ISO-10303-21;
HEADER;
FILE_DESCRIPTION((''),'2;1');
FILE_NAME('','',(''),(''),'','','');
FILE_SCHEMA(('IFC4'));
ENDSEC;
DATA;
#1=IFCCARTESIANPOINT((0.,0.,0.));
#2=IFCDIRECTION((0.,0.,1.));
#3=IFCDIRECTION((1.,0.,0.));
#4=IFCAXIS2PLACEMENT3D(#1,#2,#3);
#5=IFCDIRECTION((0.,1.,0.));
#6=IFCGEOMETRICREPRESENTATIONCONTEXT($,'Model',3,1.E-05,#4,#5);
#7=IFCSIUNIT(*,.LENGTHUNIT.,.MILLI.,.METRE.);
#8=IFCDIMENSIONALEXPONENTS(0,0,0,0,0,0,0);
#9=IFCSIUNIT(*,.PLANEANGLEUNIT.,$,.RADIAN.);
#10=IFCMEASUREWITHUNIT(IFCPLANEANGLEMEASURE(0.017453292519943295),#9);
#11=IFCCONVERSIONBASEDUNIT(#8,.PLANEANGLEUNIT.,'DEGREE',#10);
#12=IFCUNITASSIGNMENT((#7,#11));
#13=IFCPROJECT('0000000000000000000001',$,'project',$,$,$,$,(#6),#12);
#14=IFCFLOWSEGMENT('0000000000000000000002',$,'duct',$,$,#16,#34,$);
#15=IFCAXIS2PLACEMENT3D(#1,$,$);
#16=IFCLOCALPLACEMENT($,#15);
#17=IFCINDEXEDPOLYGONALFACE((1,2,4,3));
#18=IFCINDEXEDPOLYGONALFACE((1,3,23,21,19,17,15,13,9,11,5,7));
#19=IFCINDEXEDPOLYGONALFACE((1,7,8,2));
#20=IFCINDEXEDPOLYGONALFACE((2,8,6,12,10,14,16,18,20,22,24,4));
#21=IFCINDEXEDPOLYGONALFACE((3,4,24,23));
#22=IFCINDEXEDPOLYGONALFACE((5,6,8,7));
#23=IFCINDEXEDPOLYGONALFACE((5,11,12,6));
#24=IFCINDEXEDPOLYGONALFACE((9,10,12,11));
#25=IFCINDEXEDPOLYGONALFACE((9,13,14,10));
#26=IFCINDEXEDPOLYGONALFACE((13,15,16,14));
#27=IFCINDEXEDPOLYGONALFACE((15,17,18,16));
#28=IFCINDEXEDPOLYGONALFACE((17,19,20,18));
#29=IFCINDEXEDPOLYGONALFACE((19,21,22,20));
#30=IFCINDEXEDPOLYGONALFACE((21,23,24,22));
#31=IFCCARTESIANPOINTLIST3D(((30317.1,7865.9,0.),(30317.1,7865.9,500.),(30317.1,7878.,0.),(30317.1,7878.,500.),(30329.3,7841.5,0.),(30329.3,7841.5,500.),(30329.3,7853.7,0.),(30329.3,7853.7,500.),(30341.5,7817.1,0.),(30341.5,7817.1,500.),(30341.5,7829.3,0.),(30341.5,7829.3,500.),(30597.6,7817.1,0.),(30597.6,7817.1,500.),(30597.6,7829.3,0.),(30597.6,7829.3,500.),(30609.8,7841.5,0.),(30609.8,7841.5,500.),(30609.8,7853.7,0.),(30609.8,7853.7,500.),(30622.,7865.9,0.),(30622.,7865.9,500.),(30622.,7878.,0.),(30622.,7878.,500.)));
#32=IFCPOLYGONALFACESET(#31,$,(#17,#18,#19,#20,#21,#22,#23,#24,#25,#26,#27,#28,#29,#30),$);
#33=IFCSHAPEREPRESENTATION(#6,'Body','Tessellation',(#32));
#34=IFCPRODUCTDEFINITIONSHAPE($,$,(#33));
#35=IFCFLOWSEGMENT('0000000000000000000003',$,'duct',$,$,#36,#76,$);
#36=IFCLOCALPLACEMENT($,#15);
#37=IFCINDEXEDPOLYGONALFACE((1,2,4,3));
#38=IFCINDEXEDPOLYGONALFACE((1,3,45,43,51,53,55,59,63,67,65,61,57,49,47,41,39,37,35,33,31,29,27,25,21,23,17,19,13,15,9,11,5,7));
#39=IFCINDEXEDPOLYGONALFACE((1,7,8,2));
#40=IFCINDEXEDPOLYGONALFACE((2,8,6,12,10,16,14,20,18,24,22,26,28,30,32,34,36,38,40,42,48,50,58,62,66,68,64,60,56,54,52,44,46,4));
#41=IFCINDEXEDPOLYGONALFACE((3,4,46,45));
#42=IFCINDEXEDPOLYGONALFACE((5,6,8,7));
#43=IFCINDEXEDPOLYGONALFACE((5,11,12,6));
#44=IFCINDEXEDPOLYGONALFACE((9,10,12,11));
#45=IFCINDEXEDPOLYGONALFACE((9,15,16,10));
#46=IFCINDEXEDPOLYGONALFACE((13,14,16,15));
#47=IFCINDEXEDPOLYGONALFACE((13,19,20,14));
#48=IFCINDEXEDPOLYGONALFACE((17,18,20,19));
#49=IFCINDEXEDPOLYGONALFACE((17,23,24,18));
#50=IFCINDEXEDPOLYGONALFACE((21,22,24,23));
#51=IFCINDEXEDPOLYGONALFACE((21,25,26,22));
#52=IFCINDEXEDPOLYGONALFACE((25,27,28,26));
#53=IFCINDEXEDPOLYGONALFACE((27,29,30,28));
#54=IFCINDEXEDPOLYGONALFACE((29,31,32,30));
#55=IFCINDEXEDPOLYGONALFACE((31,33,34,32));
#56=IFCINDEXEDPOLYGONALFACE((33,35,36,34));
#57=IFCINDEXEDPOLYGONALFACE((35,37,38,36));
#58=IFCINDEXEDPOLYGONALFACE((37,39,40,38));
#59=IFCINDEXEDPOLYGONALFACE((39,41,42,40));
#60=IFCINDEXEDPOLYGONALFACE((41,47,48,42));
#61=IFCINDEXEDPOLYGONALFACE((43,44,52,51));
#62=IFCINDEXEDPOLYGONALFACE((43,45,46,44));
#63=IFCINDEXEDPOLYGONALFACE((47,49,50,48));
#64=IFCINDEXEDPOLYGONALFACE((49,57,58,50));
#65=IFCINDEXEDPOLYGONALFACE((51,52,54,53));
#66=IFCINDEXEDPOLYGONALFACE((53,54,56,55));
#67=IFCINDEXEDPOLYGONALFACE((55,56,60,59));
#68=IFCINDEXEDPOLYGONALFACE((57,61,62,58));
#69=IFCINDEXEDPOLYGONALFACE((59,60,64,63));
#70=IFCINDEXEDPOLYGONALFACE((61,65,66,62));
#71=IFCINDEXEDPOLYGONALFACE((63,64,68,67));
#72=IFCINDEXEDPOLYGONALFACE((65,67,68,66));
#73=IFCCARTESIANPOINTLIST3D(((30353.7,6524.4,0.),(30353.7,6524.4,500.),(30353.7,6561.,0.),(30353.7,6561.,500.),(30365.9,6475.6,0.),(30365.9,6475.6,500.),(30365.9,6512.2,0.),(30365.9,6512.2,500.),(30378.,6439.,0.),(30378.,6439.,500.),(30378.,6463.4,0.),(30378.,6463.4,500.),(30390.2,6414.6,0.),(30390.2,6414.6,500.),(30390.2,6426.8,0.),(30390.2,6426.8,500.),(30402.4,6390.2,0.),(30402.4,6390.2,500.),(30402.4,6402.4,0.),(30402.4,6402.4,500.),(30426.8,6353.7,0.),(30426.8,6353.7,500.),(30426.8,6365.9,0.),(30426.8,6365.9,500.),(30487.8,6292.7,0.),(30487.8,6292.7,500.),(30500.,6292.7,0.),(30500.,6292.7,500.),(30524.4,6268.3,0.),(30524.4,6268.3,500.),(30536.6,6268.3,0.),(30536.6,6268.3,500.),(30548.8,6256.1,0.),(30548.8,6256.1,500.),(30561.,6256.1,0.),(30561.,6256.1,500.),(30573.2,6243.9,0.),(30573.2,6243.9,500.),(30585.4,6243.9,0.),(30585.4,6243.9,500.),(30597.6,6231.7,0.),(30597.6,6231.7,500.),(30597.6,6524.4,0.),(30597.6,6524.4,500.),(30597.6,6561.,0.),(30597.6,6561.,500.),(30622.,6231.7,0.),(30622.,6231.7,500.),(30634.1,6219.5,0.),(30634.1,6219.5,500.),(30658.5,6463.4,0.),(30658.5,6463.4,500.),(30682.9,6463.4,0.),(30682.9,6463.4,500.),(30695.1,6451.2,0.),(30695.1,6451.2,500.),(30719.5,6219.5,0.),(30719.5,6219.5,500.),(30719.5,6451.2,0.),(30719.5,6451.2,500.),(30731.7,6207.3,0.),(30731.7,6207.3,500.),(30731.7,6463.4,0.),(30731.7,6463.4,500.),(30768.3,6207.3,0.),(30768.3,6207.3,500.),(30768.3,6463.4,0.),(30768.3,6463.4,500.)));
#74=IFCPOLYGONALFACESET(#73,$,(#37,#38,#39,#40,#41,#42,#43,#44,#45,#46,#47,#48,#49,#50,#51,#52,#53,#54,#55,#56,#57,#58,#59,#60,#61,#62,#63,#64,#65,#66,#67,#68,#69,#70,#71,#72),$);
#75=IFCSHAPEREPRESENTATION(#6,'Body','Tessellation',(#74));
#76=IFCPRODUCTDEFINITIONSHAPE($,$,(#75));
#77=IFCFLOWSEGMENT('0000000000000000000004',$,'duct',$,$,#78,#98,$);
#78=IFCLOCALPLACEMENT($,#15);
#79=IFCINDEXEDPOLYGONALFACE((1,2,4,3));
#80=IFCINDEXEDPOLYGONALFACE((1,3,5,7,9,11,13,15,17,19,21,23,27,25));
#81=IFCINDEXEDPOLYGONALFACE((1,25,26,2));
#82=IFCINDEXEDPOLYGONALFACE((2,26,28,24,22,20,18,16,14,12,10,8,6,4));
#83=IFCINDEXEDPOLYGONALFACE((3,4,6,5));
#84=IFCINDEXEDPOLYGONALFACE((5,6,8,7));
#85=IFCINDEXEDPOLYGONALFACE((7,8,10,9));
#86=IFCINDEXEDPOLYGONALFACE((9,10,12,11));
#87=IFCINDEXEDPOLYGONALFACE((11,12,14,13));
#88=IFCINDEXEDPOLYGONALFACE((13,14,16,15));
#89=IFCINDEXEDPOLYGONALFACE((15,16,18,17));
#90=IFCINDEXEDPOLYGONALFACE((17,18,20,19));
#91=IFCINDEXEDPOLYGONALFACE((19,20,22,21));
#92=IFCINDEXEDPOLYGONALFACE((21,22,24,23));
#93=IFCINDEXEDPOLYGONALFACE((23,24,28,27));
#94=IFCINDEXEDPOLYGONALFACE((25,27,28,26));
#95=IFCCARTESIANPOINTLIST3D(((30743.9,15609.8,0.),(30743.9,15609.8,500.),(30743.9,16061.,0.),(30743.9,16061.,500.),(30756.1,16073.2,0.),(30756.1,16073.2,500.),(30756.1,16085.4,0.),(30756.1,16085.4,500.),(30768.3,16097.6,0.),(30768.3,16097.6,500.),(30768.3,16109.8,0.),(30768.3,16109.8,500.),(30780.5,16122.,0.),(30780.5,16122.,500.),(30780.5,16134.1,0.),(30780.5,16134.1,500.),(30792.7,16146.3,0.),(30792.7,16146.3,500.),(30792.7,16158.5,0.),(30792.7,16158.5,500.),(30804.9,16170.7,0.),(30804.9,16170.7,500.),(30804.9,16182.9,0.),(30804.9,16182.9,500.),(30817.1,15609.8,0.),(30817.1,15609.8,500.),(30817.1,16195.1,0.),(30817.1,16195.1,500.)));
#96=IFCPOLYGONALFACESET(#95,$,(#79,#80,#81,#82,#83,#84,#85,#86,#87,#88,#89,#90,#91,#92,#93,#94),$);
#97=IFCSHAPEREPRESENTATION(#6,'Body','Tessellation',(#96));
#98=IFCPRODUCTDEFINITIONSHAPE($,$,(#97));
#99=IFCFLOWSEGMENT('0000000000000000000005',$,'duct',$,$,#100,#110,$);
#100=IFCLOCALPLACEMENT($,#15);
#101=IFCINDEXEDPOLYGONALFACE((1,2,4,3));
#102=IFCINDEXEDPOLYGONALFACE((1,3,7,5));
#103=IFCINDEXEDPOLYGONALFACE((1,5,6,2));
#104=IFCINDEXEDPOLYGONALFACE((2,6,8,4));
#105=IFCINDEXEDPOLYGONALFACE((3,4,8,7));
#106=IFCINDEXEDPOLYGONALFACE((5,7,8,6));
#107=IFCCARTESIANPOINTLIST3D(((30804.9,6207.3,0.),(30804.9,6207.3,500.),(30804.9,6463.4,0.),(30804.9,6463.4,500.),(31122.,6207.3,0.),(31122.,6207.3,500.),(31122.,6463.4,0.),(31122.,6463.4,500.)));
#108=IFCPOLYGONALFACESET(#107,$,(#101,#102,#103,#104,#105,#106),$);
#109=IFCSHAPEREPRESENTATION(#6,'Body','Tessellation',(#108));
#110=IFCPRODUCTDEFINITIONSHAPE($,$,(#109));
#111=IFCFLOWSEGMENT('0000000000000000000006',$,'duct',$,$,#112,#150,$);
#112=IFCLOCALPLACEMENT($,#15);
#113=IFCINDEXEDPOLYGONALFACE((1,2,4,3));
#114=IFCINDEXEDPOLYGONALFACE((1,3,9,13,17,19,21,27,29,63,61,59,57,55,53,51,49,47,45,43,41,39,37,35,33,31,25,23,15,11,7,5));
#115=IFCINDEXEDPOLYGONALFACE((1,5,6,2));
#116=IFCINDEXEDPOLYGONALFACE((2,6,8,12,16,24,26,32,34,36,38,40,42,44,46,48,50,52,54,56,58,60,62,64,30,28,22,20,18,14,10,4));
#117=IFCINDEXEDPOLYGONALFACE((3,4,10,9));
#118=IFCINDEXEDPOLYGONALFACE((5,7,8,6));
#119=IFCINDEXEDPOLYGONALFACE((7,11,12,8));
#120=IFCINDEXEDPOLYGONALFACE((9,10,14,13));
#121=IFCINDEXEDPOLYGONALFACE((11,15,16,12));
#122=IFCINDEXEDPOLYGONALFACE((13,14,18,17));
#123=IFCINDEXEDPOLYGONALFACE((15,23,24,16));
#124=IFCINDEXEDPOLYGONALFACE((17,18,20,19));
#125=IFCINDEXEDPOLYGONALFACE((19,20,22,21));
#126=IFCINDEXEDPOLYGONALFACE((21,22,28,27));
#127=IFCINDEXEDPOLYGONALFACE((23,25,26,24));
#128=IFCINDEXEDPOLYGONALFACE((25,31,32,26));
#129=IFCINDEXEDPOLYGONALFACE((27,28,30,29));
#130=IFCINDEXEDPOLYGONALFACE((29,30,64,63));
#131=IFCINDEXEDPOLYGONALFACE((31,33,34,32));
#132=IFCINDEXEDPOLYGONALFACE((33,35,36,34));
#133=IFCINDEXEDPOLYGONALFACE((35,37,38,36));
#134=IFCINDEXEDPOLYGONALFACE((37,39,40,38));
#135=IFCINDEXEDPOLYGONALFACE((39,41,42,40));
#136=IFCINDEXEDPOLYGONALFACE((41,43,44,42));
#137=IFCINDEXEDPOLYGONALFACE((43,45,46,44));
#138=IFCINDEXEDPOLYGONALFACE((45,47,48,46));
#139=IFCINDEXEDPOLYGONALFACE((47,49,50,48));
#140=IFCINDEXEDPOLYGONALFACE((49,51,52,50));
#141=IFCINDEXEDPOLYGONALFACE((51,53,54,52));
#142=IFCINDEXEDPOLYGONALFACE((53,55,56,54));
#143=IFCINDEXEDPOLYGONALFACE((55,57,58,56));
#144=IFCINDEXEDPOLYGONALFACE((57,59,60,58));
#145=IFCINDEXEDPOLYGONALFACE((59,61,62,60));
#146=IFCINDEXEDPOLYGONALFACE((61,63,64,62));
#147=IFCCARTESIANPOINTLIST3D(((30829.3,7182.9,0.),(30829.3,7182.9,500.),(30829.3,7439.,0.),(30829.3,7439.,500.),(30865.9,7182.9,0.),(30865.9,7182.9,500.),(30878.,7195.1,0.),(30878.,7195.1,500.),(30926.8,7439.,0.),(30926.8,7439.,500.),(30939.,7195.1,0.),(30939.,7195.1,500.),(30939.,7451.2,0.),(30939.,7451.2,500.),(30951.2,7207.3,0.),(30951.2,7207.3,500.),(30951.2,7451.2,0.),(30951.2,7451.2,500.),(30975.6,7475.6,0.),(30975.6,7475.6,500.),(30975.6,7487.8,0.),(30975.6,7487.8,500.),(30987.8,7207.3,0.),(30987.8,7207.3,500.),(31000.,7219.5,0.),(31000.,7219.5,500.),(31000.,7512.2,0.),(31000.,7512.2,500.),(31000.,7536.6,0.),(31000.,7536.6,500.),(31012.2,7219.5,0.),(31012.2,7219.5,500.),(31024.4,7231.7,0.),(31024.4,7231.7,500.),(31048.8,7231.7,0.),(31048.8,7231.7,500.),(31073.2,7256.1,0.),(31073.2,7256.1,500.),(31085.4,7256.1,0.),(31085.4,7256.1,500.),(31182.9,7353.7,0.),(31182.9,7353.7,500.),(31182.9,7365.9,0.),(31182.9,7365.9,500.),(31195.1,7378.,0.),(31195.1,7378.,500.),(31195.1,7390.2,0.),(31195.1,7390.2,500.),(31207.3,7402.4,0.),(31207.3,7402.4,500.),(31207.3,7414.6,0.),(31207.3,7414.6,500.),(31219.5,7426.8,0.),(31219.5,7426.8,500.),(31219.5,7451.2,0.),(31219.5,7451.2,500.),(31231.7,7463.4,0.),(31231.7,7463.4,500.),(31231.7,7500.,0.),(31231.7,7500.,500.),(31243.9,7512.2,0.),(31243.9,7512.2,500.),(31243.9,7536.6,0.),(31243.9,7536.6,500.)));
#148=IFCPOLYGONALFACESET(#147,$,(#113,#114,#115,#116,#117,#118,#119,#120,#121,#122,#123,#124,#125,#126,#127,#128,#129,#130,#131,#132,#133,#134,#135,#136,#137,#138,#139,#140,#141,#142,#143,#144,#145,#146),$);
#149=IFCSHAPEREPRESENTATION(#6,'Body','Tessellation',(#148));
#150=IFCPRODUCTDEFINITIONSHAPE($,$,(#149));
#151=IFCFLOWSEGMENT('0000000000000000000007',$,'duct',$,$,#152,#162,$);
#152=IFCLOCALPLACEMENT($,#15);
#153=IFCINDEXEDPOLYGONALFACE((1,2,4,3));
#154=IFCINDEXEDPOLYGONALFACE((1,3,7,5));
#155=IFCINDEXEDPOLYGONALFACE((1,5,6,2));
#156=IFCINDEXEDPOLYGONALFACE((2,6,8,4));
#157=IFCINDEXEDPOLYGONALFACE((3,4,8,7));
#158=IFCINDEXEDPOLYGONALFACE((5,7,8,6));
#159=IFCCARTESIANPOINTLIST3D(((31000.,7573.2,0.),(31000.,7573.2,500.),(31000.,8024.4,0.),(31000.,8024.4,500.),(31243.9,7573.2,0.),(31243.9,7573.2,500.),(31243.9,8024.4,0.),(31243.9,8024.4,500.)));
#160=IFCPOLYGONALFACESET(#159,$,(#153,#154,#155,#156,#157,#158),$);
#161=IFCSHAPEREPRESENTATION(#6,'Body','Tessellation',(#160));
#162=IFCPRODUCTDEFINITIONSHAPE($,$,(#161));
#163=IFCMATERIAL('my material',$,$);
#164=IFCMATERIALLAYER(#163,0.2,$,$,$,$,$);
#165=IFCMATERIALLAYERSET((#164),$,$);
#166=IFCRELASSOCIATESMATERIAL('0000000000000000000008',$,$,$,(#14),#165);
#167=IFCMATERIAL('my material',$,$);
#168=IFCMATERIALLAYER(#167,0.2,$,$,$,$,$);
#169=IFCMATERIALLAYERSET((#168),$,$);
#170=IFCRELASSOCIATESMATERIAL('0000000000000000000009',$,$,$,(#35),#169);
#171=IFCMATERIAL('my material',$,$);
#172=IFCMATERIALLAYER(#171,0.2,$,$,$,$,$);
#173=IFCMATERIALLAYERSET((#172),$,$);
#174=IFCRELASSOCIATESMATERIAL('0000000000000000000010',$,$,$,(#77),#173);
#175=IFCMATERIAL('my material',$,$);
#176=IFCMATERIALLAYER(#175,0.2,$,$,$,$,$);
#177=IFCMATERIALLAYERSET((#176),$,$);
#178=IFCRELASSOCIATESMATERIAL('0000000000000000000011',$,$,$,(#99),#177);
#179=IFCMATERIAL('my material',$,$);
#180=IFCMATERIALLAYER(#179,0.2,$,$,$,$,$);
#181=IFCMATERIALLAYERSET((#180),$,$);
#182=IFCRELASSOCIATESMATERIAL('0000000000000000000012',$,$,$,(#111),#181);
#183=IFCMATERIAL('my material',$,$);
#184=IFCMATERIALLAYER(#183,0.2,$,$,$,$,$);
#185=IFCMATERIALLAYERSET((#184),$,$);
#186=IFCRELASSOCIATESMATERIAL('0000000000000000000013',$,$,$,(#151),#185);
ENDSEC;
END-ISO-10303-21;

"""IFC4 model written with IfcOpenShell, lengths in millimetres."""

from ifc_helpers import new_model, entity, si_unit, converted_unit, direction, origin_with_axes, place, context, project, polyline, outline, extrude, material, layer, layer_set, layer_usage, element, save


model = new_model("IFC4")

# Units and contexts
model_context = context("Model", 3, precision=1e-05, world=origin_with_axes(), true_north=direction((0.0, 1.0, 0.0)))
ifc_project = project(units=[si_unit("LENGTHUNIT", "METRE", prefix="MILLI"), converted_unit("PLANEANGLEUNIT", "DEGREE", entity("IfcPlaneAngleMeasure", 0.017453292519943295), si_unit("PLANEANGLEUNIT", "RADIAN"), dimensions=[0, 0, 0, 0, 0, 0, 0])], contexts=[model_context])

# Flow segments
ifc_material_1 = material(Name="my material")
ifc_layer_1 = layer(ifc_material_1, 0.2)
ifc_layer_set_1 = layer_set([ifc_layer_1])
ifc_layer_usage_1 = layer_usage(ifc_layer_set_1, "AXIS2", "POSITIVE", -0.1)
flow_segment_1_placement = place(None, origin_with_axes())
element("IfcFlowSegment", 1, at=flow_segment_1_placement, material=ifc_layer_usage_1, Name="duct", context=model_context, shape_type="SweptSolid", body=[
    extrude(outline(polyline([(30317.1, 7865.9), (30329.3, 7853.7), (30329.3, 7841.5), (30341.5, 7829.3), (30341.5, 7817.1), (30597.6, 7817.1), (30597.6, 7829.3), (30609.8, 7841.5), (30609.8, 7853.7), (30622.0, 7865.9), (30622.0, 7878.0), (30317.1, 7878.0), (30317.1, 7865.9)])), origin_with_axes(), (0.0, 0.0, 1.0), 500.0),
])
ifc_material_2 = material(Name="my material")
ifc_layer_2 = layer(ifc_material_2, 0.2)
ifc_layer_set_2 = layer_set([ifc_layer_2])
ifc_layer_usage_2 = layer_usage(ifc_layer_set_2, "AXIS2", "POSITIVE", -0.1)
flow_segment_2_placement = place(None, origin_with_axes())
element("IfcFlowSegment", 2, at=flow_segment_2_placement, material=ifc_layer_usage_2, Name="duct", context=model_context, shape_type="SweptSolid", body=[
    extrude(outline(polyline([(30353.7, 6524.4), (30365.9, 6512.2), (30365.9, 6475.6), (30378.0, 6463.4), (30378.0, 6439.0), (30390.2, 6426.8), (30390.2, 6414.6), (30402.4, 6402.4), (30402.4, 6390.2), (30426.8, 6365.9), (30426.8, 6353.7), (30487.8, 6292.7), (30500.0, 6292.7), (30524.4, 6268.3), (30536.6, 6268.3), (30548.8, 6256.1), (30561.0, 6256.1), (30573.2, 6243.9), (30585.4, 6243.9), (30597.6, 6231.7), (30622.0, 6231.7), (30634.1, 6219.5), (30719.5, 6219.5), (30731.7, 6207.3), (30768.3, 6207.3), (30768.3, 6463.4), (30731.7, 6463.4), (30719.5, 6451.2), (30695.1, 6451.2), (30682.9, 6463.4), (30658.5, 6463.4), (30597.6, 6524.4), (30597.6, 6561.0), (30353.7, 6561.0), (30353.7, 6524.4)])), origin_with_axes(), (0.0, 0.0, 1.0), 500.0),
])
ifc_material_3 = material(Name="my material")
ifc_layer_3 = layer(ifc_material_3, 0.2)
ifc_layer_set_3 = layer_set([ifc_layer_3])
ifc_layer_usage_3 = layer_usage(ifc_layer_set_3, "AXIS2", "POSITIVE", -0.1)
flow_segment_3_placement = place(None, origin_with_axes())
element("IfcFlowSegment", 3, at=flow_segment_3_placement, material=ifc_layer_usage_3, Name="duct", context=model_context, shape_type="SweptSolid", body=[
    extrude(outline(polyline([(30743.9, 15609.8), (30817.1, 15609.8), (30817.1, 16207.3), (30817.1, 16195.1), (30804.9, 16182.9), (30804.9, 16170.7), (30792.7, 16158.5), (30792.7, 16146.3), (30780.5, 16134.1), (30780.5, 16122.0), (30768.3, 16109.8), (30768.3, 16097.6), (30756.1, 16085.4), (30756.1, 16073.2), (30743.9, 16061.0), (30743.9, 15609.8)])), origin_with_axes(), (0.0, 0.0, 1.0), 500.0),
])
ifc_material_4 = material(Name="my material")
ifc_layer_4 = layer(ifc_material_4, 0.2)
ifc_layer_set_4 = layer_set([ifc_layer_4])
ifc_layer_usage_4 = layer_usage(ifc_layer_set_4, "AXIS2", "POSITIVE", -0.1)
flow_segment_4_placement = place(None, origin_with_axes())
element("IfcFlowSegment", 4, at=flow_segment_4_placement, material=ifc_layer_usage_4, Name="duct", context=model_context, shape_type="SweptSolid", body=[
    extrude(outline(polyline([(30804.9, 6207.3), (31122.0, 6207.3), (31122.0, 6463.4), (30804.9, 6463.4), (30804.9, 6207.3)])), origin_with_axes(), (0.0, 0.0, 1.0), 500.0),
])
ifc_material_5 = material(Name="my material")
ifc_layer_5 = layer(ifc_material_5, 0.2)
ifc_layer_set_5 = layer_set([ifc_layer_5])
ifc_layer_usage_5 = layer_usage(ifc_layer_set_5, "AXIS2", "POSITIVE", -0.1)
flow_segment_5_placement = place(None, origin_with_axes())
element("IfcFlowSegment", 5, at=flow_segment_5_placement, material=ifc_layer_usage_5, Name="duct", context=model_context, shape_type="SweptSolid", body=[
    extrude(outline(polyline([(30829.3, 7182.9), (30865.9, 7182.9), (30878.0, 7195.1), (30939.0, 7195.1), (30951.2, 7207.3), (30987.8, 7207.3), (31000.0, 7219.5), (31012.2, 7219.5), (31024.4, 7231.7), (31048.8, 7231.7), (31073.2, 7256.1), (31085.4, 7256.1), (31182.9, 7353.7), (31182.9, 7365.9), (31195.1, 7378.0), (31195.1, 7390.2), (31207.3, 7402.4), (31207.3, 7414.6), (31219.5, 7426.8), (31219.5, 7451.2), (31231.7, 7463.4), (31231.7, 7500.0), (31243.9, 7512.2), (31243.9, 7536.6), (31000.0, 7536.6), (31000.0, 7512.2), (30975.6, 7487.8), (30975.6, 7475.6), (30951.2, 7451.2), (30939.0, 7451.2), (30926.8, 7439.0), (30829.3, 7439.0), (30829.3, 7182.9)])), origin_with_axes(), (0.0, 0.0, 1.0), 500.0),
])
ifc_material_6 = material(Name="my material")
ifc_layer_6 = layer(ifc_material_6, 0.2)
ifc_layer_set_6 = layer_set([ifc_layer_6])
ifc_layer_usage_6 = layer_usage(ifc_layer_set_6, "AXIS2", "POSITIVE", -0.1)
flow_segment_6_placement = place(None, origin_with_axes())
element("IfcFlowSegment", 6, at=flow_segment_6_placement, material=ifc_layer_usage_6, Name="duct", context=model_context, shape_type="SweptSolid", body=[
    extrude(outline(polyline([(31000.0, 7573.2), (31243.9, 7573.2), (31243.9, 8024.4), (31000.0, 8024.4), (31000.0, 7573.2)])), origin_with_axes(), (0.0, 0.0, 1.0), 500.0),
])

save(model, "model.ifc")
